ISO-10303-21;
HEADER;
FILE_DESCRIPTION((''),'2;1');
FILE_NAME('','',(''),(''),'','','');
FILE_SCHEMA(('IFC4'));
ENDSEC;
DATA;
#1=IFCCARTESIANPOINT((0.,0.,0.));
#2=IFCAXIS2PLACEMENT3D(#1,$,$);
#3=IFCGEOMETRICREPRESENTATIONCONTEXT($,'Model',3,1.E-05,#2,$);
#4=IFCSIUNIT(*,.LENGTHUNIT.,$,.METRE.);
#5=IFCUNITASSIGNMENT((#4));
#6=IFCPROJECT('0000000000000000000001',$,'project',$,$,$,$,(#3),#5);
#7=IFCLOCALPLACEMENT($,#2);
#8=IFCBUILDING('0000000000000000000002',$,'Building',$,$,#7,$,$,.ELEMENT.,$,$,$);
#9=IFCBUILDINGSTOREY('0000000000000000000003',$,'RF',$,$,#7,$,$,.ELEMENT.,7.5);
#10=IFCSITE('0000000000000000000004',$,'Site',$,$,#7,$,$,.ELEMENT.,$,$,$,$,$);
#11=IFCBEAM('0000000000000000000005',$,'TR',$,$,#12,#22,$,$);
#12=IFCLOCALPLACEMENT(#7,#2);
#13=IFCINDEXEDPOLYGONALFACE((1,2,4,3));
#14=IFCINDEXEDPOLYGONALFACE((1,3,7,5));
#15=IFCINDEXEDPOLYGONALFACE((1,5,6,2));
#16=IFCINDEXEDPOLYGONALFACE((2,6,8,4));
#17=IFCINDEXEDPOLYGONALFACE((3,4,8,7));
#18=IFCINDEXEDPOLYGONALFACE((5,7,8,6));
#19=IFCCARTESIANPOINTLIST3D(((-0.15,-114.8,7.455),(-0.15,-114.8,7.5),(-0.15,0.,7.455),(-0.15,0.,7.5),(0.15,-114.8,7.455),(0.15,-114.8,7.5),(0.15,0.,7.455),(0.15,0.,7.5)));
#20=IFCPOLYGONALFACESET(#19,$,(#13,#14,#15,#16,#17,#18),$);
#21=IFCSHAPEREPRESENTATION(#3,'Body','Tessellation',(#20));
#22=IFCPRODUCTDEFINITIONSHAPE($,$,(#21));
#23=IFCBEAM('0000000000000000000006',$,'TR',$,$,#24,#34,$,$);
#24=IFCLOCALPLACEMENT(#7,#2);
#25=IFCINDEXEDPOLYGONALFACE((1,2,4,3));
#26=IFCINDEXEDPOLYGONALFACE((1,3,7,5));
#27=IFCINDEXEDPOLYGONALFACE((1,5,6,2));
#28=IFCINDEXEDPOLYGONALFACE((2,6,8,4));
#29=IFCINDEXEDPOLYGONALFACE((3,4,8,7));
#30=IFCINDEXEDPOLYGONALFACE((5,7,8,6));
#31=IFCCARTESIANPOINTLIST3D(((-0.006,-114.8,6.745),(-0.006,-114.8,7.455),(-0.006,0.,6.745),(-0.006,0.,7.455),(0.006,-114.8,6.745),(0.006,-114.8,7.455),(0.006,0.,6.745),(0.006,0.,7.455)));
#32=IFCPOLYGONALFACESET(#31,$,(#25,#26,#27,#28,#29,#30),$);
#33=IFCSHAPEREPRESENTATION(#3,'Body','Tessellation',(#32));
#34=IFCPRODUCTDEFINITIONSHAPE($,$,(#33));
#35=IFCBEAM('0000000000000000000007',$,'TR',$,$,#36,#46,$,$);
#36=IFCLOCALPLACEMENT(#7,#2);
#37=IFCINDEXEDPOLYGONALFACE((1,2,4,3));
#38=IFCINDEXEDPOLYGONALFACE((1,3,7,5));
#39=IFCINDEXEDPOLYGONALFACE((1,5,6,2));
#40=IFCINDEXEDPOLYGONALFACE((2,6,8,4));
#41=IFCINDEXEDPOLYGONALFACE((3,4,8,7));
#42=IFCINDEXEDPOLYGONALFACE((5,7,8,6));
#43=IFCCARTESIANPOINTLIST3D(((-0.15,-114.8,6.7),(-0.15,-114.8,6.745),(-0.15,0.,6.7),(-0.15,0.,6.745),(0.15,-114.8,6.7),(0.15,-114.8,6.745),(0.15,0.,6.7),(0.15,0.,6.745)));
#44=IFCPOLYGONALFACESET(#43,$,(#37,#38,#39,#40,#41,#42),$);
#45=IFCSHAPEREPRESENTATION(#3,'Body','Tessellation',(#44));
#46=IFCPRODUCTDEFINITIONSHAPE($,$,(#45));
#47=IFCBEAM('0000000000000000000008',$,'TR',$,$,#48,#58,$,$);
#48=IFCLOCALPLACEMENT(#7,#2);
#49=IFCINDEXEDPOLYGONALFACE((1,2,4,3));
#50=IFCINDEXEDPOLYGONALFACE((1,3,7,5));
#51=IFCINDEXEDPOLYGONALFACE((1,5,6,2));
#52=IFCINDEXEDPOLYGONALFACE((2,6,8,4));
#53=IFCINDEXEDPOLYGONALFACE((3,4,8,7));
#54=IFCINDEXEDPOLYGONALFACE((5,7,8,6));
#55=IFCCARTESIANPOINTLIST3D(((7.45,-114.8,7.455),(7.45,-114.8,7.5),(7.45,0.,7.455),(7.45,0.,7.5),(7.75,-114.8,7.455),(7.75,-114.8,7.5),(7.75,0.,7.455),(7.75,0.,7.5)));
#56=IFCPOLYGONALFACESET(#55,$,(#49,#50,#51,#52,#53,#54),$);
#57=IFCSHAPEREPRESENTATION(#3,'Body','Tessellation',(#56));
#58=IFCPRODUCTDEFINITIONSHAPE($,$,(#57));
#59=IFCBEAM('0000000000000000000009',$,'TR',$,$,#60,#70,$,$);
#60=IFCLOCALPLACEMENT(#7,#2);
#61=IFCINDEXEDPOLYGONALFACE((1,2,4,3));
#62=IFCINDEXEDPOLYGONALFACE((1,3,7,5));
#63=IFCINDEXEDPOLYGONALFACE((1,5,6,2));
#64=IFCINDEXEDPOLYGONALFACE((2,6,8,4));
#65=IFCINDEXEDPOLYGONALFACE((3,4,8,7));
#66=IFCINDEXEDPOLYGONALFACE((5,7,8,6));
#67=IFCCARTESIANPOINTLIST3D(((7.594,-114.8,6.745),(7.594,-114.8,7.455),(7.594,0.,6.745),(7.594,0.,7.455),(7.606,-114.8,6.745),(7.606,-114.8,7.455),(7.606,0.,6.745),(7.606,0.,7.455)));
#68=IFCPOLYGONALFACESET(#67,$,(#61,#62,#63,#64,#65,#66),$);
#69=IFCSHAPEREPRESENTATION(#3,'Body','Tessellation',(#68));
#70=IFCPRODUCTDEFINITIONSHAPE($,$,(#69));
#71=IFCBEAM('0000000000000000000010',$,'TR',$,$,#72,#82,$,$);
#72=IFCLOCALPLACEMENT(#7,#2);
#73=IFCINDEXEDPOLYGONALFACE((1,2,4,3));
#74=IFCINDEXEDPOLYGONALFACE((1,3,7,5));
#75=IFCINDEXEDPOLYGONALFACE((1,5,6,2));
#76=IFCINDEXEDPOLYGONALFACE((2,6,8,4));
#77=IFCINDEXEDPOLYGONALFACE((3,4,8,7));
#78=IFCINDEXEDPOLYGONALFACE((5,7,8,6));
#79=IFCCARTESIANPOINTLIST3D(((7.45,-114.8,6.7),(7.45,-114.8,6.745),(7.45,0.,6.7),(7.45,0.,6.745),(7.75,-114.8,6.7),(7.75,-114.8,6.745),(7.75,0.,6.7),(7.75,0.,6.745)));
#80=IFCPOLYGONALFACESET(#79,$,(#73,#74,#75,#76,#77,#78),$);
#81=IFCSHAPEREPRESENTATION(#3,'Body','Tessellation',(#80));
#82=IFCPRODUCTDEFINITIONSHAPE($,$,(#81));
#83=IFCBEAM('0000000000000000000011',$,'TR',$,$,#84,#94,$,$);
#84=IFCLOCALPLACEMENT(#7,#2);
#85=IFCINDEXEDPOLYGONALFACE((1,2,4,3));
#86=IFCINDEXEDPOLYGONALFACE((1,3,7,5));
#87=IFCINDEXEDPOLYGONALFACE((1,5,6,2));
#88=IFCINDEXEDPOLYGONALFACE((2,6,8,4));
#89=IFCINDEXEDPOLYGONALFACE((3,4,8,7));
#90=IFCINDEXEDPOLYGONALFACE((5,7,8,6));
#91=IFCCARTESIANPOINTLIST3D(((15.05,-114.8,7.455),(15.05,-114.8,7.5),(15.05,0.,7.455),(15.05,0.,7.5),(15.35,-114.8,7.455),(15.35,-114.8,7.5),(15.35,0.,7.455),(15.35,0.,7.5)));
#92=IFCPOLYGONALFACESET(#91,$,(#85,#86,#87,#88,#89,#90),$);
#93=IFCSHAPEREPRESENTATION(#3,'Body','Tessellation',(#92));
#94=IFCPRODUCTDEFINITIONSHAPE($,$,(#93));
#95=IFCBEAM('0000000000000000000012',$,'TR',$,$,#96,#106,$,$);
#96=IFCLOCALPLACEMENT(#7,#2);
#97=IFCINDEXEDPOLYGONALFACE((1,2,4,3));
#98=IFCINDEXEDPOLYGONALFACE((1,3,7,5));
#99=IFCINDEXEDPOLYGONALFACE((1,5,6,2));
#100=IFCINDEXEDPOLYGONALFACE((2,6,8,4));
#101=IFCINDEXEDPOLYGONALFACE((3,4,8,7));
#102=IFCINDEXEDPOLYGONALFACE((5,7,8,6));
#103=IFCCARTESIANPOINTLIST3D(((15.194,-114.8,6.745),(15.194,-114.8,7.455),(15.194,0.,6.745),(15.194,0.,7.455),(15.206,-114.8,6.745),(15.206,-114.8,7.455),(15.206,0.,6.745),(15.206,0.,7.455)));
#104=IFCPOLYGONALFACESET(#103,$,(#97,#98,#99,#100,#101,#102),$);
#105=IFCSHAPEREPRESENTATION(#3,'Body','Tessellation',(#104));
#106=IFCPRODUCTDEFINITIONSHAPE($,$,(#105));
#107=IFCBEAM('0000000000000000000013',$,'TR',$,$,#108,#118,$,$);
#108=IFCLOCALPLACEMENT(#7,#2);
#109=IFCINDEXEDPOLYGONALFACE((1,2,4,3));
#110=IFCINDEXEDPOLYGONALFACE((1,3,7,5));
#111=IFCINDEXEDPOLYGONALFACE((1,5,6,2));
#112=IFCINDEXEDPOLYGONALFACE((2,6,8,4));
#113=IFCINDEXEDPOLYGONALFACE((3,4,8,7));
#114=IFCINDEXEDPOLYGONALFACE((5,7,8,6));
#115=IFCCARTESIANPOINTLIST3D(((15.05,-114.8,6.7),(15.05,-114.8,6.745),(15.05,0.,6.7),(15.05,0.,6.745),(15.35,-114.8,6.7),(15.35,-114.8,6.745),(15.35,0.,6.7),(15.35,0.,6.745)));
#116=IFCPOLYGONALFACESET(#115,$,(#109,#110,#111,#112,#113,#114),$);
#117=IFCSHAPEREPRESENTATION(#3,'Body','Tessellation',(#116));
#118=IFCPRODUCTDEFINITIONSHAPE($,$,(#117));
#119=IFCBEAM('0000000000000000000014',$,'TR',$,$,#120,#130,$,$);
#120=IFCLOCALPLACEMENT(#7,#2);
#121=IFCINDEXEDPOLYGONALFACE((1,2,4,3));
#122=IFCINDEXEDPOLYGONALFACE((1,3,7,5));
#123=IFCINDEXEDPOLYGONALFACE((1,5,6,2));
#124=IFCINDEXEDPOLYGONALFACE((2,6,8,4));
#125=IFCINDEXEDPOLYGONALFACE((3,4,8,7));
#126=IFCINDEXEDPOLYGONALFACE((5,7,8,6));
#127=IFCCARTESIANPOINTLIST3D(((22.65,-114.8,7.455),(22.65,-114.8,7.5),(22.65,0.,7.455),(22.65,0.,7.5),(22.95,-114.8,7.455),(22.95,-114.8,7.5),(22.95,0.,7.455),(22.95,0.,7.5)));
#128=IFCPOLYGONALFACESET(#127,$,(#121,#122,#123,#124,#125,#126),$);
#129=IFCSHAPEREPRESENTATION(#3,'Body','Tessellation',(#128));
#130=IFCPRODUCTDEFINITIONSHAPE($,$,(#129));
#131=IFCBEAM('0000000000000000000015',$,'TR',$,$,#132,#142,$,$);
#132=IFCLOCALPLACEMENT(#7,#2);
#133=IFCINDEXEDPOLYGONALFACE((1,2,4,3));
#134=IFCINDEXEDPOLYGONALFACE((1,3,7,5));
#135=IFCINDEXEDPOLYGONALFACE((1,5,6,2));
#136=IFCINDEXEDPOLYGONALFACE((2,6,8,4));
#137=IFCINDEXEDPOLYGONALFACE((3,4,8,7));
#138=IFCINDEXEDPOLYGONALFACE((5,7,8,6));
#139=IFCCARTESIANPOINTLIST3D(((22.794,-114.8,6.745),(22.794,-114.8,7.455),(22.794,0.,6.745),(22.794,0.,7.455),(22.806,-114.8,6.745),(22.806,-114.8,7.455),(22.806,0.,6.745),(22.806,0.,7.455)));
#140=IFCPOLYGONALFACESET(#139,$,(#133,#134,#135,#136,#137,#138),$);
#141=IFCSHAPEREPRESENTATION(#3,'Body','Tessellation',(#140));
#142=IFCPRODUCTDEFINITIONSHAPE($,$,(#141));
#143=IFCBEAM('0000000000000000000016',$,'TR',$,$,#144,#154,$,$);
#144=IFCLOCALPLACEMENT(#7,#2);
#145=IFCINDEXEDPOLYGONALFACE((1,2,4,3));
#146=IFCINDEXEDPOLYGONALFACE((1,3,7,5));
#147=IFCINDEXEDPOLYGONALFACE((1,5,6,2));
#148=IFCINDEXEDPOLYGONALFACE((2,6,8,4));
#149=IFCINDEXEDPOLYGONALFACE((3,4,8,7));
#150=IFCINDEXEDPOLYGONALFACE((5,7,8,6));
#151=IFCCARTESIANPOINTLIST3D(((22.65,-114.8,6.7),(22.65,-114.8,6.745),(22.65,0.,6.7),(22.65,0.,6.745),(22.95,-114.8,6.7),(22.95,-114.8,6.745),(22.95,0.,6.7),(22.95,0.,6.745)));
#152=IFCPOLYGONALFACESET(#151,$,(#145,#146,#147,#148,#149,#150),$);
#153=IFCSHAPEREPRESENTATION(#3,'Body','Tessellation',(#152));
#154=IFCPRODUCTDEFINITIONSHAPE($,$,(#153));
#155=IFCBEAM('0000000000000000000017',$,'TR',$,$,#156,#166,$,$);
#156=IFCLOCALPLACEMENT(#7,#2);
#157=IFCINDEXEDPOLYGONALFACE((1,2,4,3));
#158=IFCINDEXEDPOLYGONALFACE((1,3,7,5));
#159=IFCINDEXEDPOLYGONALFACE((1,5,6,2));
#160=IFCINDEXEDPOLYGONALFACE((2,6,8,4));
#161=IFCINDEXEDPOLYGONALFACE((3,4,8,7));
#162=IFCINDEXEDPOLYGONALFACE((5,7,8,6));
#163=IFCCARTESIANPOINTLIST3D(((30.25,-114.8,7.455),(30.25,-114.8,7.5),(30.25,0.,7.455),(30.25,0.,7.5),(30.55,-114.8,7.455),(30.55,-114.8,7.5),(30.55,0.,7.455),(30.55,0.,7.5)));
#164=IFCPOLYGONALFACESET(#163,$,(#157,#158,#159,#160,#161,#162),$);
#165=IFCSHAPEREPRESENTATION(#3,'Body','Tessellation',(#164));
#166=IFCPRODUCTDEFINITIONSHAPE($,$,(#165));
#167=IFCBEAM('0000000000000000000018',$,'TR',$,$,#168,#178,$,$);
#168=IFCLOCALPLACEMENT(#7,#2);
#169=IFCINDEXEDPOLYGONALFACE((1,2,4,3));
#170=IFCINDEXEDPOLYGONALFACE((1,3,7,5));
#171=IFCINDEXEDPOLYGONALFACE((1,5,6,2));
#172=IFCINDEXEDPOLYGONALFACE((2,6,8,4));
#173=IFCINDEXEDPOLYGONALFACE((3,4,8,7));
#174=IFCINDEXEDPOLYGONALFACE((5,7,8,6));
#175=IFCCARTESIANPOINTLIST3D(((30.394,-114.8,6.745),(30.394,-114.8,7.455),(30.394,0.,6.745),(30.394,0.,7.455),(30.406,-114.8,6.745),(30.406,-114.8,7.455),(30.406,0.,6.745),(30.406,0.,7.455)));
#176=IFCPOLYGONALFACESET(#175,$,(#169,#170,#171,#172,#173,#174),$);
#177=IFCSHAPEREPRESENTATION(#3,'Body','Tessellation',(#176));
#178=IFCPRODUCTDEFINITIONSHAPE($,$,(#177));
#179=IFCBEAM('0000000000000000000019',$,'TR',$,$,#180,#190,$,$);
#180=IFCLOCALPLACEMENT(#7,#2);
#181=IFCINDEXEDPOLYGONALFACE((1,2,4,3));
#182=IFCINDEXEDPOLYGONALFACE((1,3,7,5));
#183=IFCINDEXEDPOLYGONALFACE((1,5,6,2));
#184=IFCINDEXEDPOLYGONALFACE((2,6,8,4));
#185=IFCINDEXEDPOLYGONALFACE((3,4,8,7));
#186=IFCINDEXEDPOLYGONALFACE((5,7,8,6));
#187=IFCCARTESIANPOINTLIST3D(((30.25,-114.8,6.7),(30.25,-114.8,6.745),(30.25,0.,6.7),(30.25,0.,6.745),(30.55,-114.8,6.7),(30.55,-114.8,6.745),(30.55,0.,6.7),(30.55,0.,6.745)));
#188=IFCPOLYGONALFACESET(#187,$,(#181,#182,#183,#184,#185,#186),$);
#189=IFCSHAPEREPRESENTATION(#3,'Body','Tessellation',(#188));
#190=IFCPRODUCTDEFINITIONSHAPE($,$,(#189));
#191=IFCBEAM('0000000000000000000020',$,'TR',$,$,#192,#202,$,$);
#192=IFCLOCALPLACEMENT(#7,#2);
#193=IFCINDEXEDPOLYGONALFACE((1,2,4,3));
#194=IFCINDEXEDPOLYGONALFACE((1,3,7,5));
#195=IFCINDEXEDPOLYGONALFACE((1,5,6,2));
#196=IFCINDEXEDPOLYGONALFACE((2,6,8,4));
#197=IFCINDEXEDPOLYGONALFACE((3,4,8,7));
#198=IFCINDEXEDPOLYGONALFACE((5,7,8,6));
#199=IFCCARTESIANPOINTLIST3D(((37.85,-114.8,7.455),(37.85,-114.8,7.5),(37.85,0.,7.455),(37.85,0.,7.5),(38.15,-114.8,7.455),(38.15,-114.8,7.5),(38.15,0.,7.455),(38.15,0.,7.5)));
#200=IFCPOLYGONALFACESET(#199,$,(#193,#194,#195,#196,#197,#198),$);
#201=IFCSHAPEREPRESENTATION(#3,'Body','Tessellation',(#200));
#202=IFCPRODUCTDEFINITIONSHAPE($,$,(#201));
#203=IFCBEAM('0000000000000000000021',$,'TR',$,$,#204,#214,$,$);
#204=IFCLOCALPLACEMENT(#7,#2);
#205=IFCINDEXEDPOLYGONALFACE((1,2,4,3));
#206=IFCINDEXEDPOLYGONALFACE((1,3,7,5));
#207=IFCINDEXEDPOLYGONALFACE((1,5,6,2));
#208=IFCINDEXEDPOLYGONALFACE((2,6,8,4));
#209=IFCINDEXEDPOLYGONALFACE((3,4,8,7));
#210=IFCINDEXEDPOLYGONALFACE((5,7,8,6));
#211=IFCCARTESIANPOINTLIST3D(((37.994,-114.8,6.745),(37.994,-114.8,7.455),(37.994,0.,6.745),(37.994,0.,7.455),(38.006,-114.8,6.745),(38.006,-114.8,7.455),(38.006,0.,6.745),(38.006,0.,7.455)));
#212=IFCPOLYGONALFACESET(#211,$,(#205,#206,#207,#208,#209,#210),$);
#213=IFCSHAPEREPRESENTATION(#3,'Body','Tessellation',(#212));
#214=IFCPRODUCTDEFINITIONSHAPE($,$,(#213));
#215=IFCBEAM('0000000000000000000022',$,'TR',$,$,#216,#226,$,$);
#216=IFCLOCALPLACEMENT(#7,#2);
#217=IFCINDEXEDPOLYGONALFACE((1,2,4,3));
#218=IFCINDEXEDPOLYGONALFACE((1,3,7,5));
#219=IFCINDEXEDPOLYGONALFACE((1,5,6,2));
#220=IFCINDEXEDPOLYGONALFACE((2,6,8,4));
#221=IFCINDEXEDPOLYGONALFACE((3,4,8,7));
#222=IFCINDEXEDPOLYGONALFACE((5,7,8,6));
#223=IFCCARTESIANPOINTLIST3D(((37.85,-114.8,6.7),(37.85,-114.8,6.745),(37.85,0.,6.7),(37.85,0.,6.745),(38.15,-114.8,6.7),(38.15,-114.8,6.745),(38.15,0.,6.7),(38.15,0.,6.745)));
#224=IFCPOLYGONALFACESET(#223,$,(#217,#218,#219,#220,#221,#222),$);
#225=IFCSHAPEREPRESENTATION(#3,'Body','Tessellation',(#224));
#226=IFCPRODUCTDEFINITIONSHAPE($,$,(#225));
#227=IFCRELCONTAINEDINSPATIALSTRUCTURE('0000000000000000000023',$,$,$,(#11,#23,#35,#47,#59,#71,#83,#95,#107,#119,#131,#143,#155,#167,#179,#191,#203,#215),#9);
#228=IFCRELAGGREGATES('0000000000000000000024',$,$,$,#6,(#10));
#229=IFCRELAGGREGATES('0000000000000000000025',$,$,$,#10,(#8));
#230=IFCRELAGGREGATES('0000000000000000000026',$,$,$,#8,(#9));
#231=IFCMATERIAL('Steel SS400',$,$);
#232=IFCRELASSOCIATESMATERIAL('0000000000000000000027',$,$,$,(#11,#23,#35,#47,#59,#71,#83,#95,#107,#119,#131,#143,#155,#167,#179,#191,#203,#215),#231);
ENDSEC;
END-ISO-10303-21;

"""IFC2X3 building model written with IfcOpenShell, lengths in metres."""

from ifc_helpers import new_model, si_unit, frame, origin, origin_2d, place, context, project, spatial, rectangle, extrude, material, element, save


model = new_model("IFC2X3")

# Units and contexts
model_context = context("Model", 3, precision=1e-05, world=origin())
ifc_project = project(units=[si_unit("LENGTHUNIT", "METRE")], contexts=[model_context])

# Site, building, storey
placement = place(None, origin())
site = spatial("IfcSite", under=ifc_project, at=placement, Name="Site", CompositionType="ELEMENT")
building = spatial("IfcBuilding", under=site, at=placement, Name="Building", CompositionType="ELEMENT")
storey = spatial("IfcBuildingStorey", under=building, at=placement, Name="RF", CompositionType="ELEMENT", Elevation=7.5)

# Beams
ifc_material = material(Name="Steel SS400")
beam_1_placement = place(None, frame((0.0, -57.4, 7.455)))
element("IfcBeam", 1, at=beam_1_placement, inside=storey, material=ifc_material, Name="TR", context=model_context, shape_type="SweptSolid", body=[
    extrude(rectangle(XDim=0.3, YDim=114.8, at=origin_2d()), origin(), (0.0, 0.0, 1.0), 0.045),
])
beam_2_placement = place(None, frame((0.0, -57.4, 6.745)))
element("IfcBeam", 2, at=beam_2_placement, inside=storey, material=ifc_material, Name="TR", context=model_context, shape_type="SweptSolid", body=[
    extrude(rectangle(XDim=0.012, YDim=114.8, at=origin_2d()), origin(), (0.0, 0.0, 1.0), 0.71),
])
for number, where, name in (
    (3, (0.0, -57.4, 6.7), "TR"),
    (4, (7.6, -57.4, 7.455), "TR"),
):
    element("IfcBeam", number, at=place(None, frame(where)), inside=storey, material=ifc_material, Name=name, context=model_context, shape_type="SweptSolid", body=[
        extrude(rectangle(XDim=0.3, YDim=114.8, at=origin_2d()), origin(), (0.0, 0.0, 1.0), 0.045),
    ])
beam_3_placement = place(None, frame((7.6, -57.4, 6.745)))
element("IfcBeam", 5, at=beam_3_placement, inside=storey, material=ifc_material, Name="TR", context=model_context, shape_type="SweptSolid", body=[
    extrude(rectangle(XDim=0.012, YDim=114.8, at=origin_2d()), origin(), (0.0, 0.0, 1.0), 0.71),
])
for number, where, name in (
    (6, (7.6, -57.4, 6.7), "TR"),
    (7, (15.2, -57.4, 7.455), "TR"),
):
    element("IfcBeam", number, at=place(None, frame(where)), inside=storey, material=ifc_material, Name=name, context=model_context, shape_type="SweptSolid", body=[
        extrude(rectangle(XDim=0.3, YDim=114.8, at=origin_2d()), origin(), (0.0, 0.0, 1.0), 0.045),
    ])
beam_4_placement = place(None, frame((15.2, -57.4, 6.745)))
element("IfcBeam", 8, at=beam_4_placement, inside=storey, material=ifc_material, Name="TR", context=model_context, shape_type="SweptSolid", body=[
    extrude(rectangle(XDim=0.012, YDim=114.8, at=origin_2d()), origin(), (0.0, 0.0, 1.0), 0.71),
])
for number, where, name in (
    (9, (15.2, -57.4, 6.7), "TR"),
    (10, (22.8, -57.4, 7.455), "TR"),
):
    element("IfcBeam", number, at=place(None, frame(where)), inside=storey, material=ifc_material, Name=name, context=model_context, shape_type="SweptSolid", body=[
        extrude(rectangle(XDim=0.3, YDim=114.8, at=origin_2d()), origin(), (0.0, 0.0, 1.0), 0.045),
    ])
beam_5_placement = place(None, frame((22.8, -57.4, 6.745)))
element("IfcBeam", 11, at=beam_5_placement, inside=storey, material=ifc_material, Name="TR", context=model_context, shape_type="SweptSolid", body=[
    extrude(rectangle(XDim=0.012, YDim=114.8, at=origin_2d()), origin(), (0.0, 0.0, 1.0), 0.71),
])
for number, where, name in (
    (12, (22.8, -57.4, 6.7), "TR"),
    (13, (30.4, -57.4, 7.455), "TR"),
):
    element("IfcBeam", number, at=place(None, frame(where)), inside=storey, material=ifc_material, Name=name, context=model_context, shape_type="SweptSolid", body=[
        extrude(rectangle(XDim=0.3, YDim=114.8, at=origin_2d()), origin(), (0.0, 0.0, 1.0), 0.045),
    ])
beam_6_placement = place(None, frame((30.4, -57.4, 6.745)))
element("IfcBeam", 14, at=beam_6_placement, inside=storey, material=ifc_material, Name="TR", context=model_context, shape_type="SweptSolid", body=[
    extrude(rectangle(XDim=0.012, YDim=114.8, at=origin_2d()), origin(), (0.0, 0.0, 1.0), 0.71),
])
for number, where, name in (
    (15, (30.4, -57.4, 6.7), "TR"),
    (16, (38.0, -57.4, 7.455), "TR"),
):
    element("IfcBeam", number, at=place(None, frame(where)), inside=storey, material=ifc_material, Name=name, context=model_context, shape_type="SweptSolid", body=[
        extrude(rectangle(XDim=0.3, YDim=114.8, at=origin_2d()), origin(), (0.0, 0.0, 1.0), 0.045),
    ])
beam_7_placement = place(None, frame((38.0, -57.4, 6.745)))
element("IfcBeam", 17, at=beam_7_placement, inside=storey, material=ifc_material, Name="TR", context=model_context, shape_type="SweptSolid", body=[
    extrude(rectangle(XDim=0.012, YDim=114.8, at=origin_2d()), origin(), (0.0, 0.0, 1.0), 0.71),
])
for number, where, name in (
    (18, (38.0, -57.4, 6.7), "TR"),
):
    element("IfcBeam", number, at=place(None, frame(where)), inside=storey, material=ifc_material, Name=name, context=model_context, shape_type="SweptSolid", body=[
        extrude(rectangle(XDim=0.3, YDim=114.8, at=origin_2d()), origin(), (0.0, 0.0, 1.0), 0.045),
    ])

save(model, "model.ifc")
